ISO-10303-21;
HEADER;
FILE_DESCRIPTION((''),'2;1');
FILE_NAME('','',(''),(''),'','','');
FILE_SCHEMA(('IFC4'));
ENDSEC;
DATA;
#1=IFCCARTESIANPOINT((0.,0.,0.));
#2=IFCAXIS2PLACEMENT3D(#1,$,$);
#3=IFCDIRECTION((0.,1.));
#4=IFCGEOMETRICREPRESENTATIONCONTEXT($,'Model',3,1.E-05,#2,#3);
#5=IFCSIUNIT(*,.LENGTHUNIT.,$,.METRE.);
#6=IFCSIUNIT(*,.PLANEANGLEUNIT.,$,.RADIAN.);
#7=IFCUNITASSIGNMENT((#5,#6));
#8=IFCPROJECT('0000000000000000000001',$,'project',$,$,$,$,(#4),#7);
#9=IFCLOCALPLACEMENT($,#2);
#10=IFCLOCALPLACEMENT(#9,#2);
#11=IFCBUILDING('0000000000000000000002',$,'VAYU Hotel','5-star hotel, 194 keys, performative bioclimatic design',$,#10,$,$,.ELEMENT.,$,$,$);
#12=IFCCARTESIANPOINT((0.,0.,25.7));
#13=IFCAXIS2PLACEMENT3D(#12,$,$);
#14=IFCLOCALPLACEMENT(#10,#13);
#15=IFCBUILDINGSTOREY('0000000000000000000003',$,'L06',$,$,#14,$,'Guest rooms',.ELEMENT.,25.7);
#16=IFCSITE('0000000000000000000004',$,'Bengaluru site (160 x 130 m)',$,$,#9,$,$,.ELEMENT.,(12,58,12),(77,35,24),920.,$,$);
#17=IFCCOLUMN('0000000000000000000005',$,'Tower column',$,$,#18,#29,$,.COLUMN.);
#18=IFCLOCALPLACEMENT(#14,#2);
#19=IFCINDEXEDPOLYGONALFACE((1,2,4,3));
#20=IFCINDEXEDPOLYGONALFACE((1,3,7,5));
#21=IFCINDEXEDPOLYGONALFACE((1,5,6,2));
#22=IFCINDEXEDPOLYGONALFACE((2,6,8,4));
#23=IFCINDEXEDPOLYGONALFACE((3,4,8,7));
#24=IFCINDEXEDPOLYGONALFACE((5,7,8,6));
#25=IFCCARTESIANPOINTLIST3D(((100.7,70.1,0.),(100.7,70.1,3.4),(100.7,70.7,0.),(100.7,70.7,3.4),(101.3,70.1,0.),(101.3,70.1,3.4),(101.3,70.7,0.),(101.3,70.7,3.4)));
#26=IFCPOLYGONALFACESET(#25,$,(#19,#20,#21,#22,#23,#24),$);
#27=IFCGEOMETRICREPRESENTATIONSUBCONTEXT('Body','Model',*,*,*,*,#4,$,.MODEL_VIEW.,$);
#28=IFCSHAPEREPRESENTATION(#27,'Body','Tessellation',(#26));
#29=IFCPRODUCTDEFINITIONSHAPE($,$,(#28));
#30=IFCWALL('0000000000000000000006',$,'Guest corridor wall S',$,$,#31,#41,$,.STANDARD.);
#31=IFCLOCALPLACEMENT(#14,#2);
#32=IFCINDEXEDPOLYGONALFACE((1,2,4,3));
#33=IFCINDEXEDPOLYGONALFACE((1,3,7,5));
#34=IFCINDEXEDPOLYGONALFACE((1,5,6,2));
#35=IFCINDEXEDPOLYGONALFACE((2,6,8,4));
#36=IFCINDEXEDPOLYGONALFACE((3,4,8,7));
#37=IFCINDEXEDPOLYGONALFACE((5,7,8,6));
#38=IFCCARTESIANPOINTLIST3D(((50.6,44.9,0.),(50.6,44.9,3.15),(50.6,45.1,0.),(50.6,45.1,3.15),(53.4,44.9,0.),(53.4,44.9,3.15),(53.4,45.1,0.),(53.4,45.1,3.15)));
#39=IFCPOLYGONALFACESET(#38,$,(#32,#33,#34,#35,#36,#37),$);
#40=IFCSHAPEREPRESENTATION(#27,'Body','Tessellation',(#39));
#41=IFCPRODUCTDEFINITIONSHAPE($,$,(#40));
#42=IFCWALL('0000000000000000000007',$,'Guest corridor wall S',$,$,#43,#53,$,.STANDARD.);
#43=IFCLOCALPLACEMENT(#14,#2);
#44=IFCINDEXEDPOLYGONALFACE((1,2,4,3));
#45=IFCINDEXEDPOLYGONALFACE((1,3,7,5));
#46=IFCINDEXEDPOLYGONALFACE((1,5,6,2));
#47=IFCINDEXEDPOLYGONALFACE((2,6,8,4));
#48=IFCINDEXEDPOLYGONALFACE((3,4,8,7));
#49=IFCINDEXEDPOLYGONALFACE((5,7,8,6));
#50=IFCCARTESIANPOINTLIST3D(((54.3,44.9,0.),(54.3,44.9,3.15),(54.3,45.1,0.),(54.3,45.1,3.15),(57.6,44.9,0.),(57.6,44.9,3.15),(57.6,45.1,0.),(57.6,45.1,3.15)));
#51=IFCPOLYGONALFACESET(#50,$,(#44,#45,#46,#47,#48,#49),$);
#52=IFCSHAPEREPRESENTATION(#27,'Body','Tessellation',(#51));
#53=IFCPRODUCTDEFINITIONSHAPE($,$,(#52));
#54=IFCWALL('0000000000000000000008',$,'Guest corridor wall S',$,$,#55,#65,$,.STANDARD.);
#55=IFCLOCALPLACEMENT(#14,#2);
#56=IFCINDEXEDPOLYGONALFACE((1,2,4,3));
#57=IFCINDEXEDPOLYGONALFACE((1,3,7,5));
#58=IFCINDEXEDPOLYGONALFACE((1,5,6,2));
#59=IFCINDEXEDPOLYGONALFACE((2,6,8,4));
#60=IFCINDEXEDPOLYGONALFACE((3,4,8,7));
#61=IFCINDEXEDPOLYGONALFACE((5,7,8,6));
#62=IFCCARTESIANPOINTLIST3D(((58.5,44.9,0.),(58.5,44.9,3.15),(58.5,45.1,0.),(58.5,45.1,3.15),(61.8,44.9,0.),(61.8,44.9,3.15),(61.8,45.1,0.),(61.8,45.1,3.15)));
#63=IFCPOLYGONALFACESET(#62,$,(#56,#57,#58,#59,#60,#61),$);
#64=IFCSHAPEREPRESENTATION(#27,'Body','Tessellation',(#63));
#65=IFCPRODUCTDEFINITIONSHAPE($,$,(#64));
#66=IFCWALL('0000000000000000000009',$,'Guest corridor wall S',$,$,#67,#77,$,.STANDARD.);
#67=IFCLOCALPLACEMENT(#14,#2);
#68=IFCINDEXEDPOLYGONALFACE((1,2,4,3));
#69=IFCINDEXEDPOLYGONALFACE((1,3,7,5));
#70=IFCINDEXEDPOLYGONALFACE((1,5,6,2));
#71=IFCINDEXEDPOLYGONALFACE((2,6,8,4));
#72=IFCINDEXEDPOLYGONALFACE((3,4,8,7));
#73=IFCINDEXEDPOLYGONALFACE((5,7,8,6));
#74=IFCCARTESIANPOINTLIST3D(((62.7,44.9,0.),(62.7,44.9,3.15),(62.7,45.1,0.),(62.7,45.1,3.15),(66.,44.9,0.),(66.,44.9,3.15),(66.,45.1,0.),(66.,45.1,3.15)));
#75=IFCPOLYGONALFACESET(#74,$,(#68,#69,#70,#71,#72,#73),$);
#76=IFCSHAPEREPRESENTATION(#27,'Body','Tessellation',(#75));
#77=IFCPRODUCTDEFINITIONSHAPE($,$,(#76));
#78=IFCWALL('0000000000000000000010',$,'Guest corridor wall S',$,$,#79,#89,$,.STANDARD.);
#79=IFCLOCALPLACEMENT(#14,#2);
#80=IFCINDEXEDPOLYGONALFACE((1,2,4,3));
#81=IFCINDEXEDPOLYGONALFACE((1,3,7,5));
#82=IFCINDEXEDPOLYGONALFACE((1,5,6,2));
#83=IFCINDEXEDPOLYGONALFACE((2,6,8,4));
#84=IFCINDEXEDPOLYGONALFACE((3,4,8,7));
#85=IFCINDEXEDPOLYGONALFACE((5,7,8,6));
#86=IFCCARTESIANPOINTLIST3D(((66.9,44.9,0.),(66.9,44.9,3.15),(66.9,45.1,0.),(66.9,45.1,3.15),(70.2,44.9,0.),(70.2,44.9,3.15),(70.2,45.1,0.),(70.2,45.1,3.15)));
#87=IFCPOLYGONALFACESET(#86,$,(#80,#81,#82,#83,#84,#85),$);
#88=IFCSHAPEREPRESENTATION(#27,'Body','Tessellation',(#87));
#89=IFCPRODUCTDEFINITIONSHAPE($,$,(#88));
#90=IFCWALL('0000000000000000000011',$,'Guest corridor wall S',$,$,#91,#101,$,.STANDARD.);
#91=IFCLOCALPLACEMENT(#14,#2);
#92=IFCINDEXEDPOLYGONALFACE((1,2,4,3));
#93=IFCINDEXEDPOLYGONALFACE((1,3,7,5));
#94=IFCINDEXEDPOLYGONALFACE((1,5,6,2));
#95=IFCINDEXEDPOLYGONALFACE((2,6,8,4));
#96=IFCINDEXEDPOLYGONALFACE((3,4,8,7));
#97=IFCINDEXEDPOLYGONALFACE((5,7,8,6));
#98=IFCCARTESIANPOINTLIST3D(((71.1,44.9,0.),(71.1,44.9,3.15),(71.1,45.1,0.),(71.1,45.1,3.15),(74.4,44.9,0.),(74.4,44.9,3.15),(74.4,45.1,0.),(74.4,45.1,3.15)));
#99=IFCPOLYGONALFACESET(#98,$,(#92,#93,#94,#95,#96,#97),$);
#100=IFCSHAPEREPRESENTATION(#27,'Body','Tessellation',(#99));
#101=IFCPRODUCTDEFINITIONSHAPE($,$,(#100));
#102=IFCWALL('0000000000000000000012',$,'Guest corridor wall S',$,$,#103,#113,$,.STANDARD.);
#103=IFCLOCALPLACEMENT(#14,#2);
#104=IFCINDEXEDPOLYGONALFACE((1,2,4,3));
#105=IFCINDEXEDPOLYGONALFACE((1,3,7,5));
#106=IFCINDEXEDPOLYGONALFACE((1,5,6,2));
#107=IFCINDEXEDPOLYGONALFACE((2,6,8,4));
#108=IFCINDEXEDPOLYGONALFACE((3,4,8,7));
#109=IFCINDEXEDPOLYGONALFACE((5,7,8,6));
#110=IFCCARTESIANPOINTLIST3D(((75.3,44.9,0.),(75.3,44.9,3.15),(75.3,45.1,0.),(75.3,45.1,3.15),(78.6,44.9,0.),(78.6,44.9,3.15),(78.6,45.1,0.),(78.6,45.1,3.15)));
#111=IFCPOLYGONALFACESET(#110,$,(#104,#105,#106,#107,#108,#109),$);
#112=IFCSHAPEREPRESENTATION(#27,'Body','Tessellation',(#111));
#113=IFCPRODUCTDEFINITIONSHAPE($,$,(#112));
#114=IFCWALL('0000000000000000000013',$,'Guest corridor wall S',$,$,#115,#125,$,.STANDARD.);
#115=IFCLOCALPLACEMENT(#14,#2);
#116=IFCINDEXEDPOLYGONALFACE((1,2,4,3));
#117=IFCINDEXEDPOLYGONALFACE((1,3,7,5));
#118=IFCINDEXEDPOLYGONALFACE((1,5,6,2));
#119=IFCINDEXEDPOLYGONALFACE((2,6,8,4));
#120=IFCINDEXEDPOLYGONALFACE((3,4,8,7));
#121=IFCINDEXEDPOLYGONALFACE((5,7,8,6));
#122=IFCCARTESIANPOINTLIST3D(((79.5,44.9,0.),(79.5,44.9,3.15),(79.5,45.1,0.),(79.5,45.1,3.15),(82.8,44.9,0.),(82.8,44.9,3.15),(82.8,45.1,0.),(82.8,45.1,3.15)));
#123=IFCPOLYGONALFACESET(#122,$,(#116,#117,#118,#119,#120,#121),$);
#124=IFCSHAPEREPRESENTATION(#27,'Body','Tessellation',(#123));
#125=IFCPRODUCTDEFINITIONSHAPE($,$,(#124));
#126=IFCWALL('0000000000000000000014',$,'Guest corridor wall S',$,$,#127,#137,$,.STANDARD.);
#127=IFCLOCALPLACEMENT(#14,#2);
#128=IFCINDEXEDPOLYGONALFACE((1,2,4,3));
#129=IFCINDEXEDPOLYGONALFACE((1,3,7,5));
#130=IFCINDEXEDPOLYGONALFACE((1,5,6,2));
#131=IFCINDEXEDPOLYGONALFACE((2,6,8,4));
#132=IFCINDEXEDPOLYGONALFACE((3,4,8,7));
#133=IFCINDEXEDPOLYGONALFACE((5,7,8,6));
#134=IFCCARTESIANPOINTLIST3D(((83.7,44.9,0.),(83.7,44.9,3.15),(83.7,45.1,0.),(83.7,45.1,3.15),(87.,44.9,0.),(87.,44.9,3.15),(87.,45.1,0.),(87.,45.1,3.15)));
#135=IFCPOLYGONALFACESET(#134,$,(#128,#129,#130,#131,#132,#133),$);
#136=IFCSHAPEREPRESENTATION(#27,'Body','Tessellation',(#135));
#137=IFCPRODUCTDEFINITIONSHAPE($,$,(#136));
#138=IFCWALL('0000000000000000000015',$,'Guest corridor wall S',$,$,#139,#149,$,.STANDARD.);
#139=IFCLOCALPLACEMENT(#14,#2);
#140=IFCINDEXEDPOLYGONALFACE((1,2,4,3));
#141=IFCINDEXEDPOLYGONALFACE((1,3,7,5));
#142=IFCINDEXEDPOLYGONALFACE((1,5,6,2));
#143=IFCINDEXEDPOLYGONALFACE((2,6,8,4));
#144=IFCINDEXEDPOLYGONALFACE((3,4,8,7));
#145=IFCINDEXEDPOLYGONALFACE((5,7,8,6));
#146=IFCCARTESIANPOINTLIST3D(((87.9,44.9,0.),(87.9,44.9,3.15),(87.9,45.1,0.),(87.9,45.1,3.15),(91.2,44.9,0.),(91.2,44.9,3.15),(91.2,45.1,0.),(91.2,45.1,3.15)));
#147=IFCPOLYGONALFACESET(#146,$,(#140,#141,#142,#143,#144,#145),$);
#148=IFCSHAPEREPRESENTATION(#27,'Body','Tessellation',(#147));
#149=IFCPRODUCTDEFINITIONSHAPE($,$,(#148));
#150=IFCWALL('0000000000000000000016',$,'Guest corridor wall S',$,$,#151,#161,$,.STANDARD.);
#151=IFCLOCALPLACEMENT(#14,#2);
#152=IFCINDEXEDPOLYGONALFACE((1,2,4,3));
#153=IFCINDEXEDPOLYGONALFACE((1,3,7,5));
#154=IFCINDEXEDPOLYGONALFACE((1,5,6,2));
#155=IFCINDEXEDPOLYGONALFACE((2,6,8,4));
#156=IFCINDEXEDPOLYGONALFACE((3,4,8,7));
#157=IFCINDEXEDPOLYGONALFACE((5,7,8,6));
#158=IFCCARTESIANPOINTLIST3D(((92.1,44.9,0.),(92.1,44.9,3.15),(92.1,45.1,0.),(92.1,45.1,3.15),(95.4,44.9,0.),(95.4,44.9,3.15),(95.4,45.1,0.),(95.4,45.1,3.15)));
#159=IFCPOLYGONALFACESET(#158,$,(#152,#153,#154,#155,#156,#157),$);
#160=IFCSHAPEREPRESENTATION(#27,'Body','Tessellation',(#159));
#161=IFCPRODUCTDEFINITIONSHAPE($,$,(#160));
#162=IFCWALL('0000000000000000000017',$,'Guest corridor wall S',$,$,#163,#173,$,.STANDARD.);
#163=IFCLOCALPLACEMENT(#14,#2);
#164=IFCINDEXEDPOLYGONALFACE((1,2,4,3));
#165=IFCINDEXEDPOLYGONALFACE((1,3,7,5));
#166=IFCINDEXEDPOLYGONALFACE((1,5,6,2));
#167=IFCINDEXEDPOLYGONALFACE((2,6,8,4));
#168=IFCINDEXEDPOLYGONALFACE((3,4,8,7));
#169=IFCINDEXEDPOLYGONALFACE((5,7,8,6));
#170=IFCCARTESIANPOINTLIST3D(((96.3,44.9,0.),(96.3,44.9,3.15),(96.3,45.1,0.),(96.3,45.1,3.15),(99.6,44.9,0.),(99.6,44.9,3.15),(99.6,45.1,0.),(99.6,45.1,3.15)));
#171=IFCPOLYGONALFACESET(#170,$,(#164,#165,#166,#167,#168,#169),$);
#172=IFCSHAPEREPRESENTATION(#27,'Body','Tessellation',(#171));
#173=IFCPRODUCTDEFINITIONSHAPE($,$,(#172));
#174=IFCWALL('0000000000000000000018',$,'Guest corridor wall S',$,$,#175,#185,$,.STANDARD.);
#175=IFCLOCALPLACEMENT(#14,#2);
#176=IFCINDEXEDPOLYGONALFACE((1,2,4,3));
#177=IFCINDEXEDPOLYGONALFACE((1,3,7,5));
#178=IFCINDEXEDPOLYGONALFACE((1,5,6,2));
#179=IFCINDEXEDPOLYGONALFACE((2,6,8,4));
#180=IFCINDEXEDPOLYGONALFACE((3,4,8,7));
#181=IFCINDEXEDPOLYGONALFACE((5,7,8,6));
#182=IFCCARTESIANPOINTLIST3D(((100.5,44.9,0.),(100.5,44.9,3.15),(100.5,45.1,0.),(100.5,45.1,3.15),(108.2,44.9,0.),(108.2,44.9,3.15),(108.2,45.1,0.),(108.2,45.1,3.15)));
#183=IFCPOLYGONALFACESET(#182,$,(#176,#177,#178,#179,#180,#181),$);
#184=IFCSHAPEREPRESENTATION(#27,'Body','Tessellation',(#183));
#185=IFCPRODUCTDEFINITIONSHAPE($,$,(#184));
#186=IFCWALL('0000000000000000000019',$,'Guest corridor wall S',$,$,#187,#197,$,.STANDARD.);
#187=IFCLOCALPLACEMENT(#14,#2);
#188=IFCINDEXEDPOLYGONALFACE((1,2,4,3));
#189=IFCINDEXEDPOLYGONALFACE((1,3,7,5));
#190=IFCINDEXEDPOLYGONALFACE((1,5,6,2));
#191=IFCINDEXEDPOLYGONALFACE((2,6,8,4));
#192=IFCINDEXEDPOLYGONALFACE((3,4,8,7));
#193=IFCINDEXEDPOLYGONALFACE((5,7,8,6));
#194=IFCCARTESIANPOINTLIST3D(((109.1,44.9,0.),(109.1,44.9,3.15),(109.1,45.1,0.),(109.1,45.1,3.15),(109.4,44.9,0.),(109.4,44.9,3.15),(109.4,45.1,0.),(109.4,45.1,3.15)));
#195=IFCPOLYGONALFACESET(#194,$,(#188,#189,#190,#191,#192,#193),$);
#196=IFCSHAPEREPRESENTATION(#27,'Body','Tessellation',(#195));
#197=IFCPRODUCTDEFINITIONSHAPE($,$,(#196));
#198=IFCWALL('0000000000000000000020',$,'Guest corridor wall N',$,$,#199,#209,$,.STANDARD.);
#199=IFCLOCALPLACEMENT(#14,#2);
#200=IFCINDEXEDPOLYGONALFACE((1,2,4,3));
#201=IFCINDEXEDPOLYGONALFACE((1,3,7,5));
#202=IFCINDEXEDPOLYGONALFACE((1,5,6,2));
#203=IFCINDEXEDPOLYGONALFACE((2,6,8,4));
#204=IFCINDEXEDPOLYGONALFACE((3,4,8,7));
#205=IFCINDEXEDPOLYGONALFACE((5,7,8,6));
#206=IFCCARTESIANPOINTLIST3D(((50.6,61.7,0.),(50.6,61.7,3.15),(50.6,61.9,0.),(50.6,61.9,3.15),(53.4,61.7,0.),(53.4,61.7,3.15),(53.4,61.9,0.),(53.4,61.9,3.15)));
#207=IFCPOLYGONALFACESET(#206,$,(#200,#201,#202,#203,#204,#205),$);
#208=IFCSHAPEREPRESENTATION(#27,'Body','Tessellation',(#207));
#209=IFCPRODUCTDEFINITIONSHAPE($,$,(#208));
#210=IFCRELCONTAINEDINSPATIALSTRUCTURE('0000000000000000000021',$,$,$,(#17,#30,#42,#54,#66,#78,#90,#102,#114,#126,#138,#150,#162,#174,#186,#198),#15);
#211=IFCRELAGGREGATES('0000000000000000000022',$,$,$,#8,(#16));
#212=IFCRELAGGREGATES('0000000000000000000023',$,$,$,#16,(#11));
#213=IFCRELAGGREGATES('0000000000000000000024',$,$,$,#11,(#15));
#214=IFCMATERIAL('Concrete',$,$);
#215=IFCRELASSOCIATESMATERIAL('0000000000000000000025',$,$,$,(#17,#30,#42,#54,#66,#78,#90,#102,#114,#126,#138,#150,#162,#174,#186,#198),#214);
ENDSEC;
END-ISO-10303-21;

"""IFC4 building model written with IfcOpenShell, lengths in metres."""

from ifc_helpers import new_model, si_unit, direction, frame, origin, place, context, subcontext, project, spatial, polyline, outline, extrude, material, element, save


model = new_model("IFC4")

# Units and contexts
model_context = context("Model", 3, precision=1e-05, world=origin(), true_north=direction((0.0, 1.0)))
body_context = subcontext(model_context, "Body", "Model", "MODEL_VIEW")
ifc_project = project(units=[si_unit("LENGTHUNIT", "METRE"), si_unit("PLANEANGLEUNIT", "RADIAN")], contexts=[model_context])

# Site, building, storey
site_placement = place(None, origin())
site = spatial("IfcSite", under=ifc_project, at=site_placement, Name="Bengaluru site (160 x 130 m)", CompositionType="ELEMENT", RefLatitude=(12, 58, 12), RefLongitude=(77, 35, 24), RefElevation=920.0)
building_placement = place(site_placement, origin())
building = spatial("IfcBuilding", under=site, at=building_placement, Name="VAYU Hotel", Description="5-star hotel, 194 keys, performative bioclimatic design", CompositionType="ELEMENT")
storey_placement = place(building_placement, frame((0.0, 0.0, 25.7)))
storey = spatial("IfcBuildingStorey", under=building, at=storey_placement, Name="L06", LongName="Guest rooms", CompositionType="ELEMENT", Elevation=25.7)

# Column
ifc_material = material(Name="Concrete")
column_1_placement = place(storey_placement, origin())
element("IfcColumn", 1, at=column_1_placement, inside=storey, material=ifc_material, Name="Tower column", PredefinedType="COLUMN", context=body_context, shape_type="SweptSolid", body=[
    extrude(outline(polyline([(100.7, 70.1), (101.3, 70.1), (101.3, 70.7), (100.7, 70.7), (100.7, 70.1)])), origin(), (0.0, 0.0, 1.0), 3.4),
])

# Walls
wall_1_placement = place(storey_placement, origin())
element("IfcWall", 2, at=wall_1_placement, inside=storey, material=ifc_material, Name="Guest corridor wall S", PredefinedType="STANDARD", context=body_context, shape_type="SweptSolid", body=[
    extrude(outline(polyline([(50.6, 45.1), (53.4, 45.1), (53.4, 44.9), (50.6, 44.9), (50.6, 45.1)])), origin(), (0.0, 0.0, 1.0), 3.15),
])
wall_2_placement = place(storey_placement, origin())
element("IfcWall", 3, at=wall_2_placement, inside=storey, material=ifc_material, Name="Guest corridor wall S", PredefinedType="STANDARD", context=body_context, shape_type="SweptSolid", body=[
    extrude(outline(polyline([(54.3, 45.1), (57.6, 45.1), (57.6, 44.9), (54.3, 44.9), (54.3, 45.1)])), origin(), (0.0, 0.0, 1.0), 3.15),
])
wall_3_placement = place(storey_placement, origin())
element("IfcWall", 4, at=wall_3_placement, inside=storey, material=ifc_material, Name="Guest corridor wall S", PredefinedType="STANDARD", context=body_context, shape_type="SweptSolid", body=[
    extrude(outline(polyline([(58.5, 45.1), (61.8, 45.1), (61.8, 44.9), (58.5, 44.9), (58.5, 45.1)])), origin(), (0.0, 0.0, 1.0), 3.15),
])
wall_4_placement = place(storey_placement, origin())
element("IfcWall", 5, at=wall_4_placement, inside=storey, material=ifc_material, Name="Guest corridor wall S", PredefinedType="STANDARD", context=body_context, shape_type="SweptSolid", body=[
    extrude(outline(polyline([(62.7, 45.1), (66.0, 45.1), (66.0, 44.9), (62.7, 44.9), (62.7, 45.1)])), origin(), (0.0, 0.0, 1.0), 3.15),
])
wall_5_placement = place(storey_placement, origin())
element("IfcWall", 6, at=wall_5_placement, inside=storey, material=ifc_material, Name="Guest corridor wall S", PredefinedType="STANDARD", context=body_context, shape_type="SweptSolid", body=[
    extrude(outline(polyline([(66.9, 45.1), (70.2, 45.1), (70.2, 44.9), (66.9, 44.9), (66.9, 45.1)])), origin(), (0.0, 0.0, 1.0), 3.15),
])
wall_6_placement = place(storey_placement, origin())
element("IfcWall", 7, at=wall_6_placement, inside=storey, material=ifc_material, Name="Guest corridor wall S", PredefinedType="STANDARD", context=body_context, shape_type="SweptSolid", body=[
    extrude(outline(polyline([(71.1, 45.1), (74.4, 45.1), (74.4, 44.9), (71.1, 44.9), (71.1, 45.1)])), origin(), (0.0, 0.0, 1.0), 3.15),
])
wall_7_placement = place(storey_placement, origin())
element("IfcWall", 8, at=wall_7_placement, inside=storey, material=ifc_material, Name="Guest corridor wall S", PredefinedType="STANDARD", context=body_context, shape_type="SweptSolid", body=[
    extrude(outline(polyline([(75.3, 45.1), (78.6, 45.1), (78.6, 44.9), (75.3, 44.9), (75.3, 45.1)])), origin(), (0.0, 0.0, 1.0), 3.15),
])
wall_8_placement = place(storey_placement, origin())
element("IfcWall", 9, at=wall_8_placement, inside=storey, material=ifc_material, Name="Guest corridor wall S", PredefinedType="STANDARD", context=body_context, shape_type="SweptSolid", body=[
    extrude(outline(polyline([(79.5, 45.1), (82.8, 45.1), (82.8, 44.9), (79.5, 44.9), (79.5, 45.1)])), origin(), (0.0, 0.0, 1.0), 3.15),
])
wall_9_placement = place(storey_placement, origin())
element("IfcWall", 10, at=wall_9_placement, inside=storey, material=ifc_material, Name="Guest corridor wall S", PredefinedType="STANDARD", context=body_context, shape_type="SweptSolid", body=[
    extrude(outline(polyline([(83.7, 45.1), (87.0, 45.1), (87.0, 44.9), (83.7, 44.9), (83.7, 45.1)])), origin(), (0.0, 0.0, 1.0), 3.15),
])
wall_10_placement = place(storey_placement, origin())
element("IfcWall", 11, at=wall_10_placement, inside=storey, material=ifc_material, Name="Guest corridor wall S", PredefinedType="STANDARD", context=body_context, shape_type="SweptSolid", body=[
    extrude(outline(polyline([(87.9, 45.1), (91.2, 45.1), (91.2, 44.9), (87.9, 44.9), (87.9, 45.1)])), origin(), (0.0, 0.0, 1.0), 3.15),
])
wall_11_placement = place(storey_placement, origin())
element("IfcWall", 12, at=wall_11_placement, inside=storey, material=ifc_material, Name="Guest corridor wall S", PredefinedType="STANDARD", context=body_context, shape_type="SweptSolid", body=[
    extrude(outline(polyline([(92.1, 45.1), (95.4, 45.1), (95.4, 44.9), (92.1, 44.9), (92.1, 45.1)])), origin(), (0.0, 0.0, 1.0), 3.15),
])
wall_12_placement = place(storey_placement, origin())
element("IfcWall", 13, at=wall_12_placement, inside=storey, material=ifc_material, Name="Guest corridor wall S", PredefinedType="STANDARD", context=body_context, shape_type="SweptSolid", body=[
    extrude(outline(polyline([(96.3, 45.1), (99.6, 45.1), (99.6, 44.9), (96.3, 44.9), (96.3, 45.1)])), origin(), (0.0, 0.0, 1.0), 3.15),
])
wall_13_placement = place(storey_placement, origin())
element("IfcWall", 14, at=wall_13_placement, inside=storey, material=ifc_material, Name="Guest corridor wall S", PredefinedType="STANDARD", context=body_context, shape_type="SweptSolid", body=[
    extrude(outline(polyline([(100.5, 45.1), (108.2, 45.1), (108.2, 44.9), (100.5, 44.9), (100.5, 45.1)])), origin(), (0.0, 0.0, 1.0), 3.15),
])
wall_14_placement = place(storey_placement, origin())
element("IfcWall", 15, at=wall_14_placement, inside=storey, material=ifc_material, Name="Guest corridor wall S", PredefinedType="STANDARD", context=body_context, shape_type="SweptSolid", body=[
    extrude(outline(polyline([(109.1, 45.1), (109.4, 45.1), (109.4, 44.9), (109.1, 44.9), (109.1, 45.1)])), origin(), (0.0, 0.0, 1.0), 3.15),
])
wall_15_placement = place(storey_placement, origin())
element("IfcWall", 16, at=wall_15_placement, inside=storey, material=ifc_material, Name="Guest corridor wall N", PredefinedType="STANDARD", context=body_context, shape_type="SweptSolid", body=[
    extrude(outline(polyline([(50.6, 61.9), (53.4, 61.9), (53.4, 61.7), (50.6, 61.7), (50.6, 61.9)])), origin(), (0.0, 0.0, 1.0), 3.15),
])

save(model, "model.ifc")
